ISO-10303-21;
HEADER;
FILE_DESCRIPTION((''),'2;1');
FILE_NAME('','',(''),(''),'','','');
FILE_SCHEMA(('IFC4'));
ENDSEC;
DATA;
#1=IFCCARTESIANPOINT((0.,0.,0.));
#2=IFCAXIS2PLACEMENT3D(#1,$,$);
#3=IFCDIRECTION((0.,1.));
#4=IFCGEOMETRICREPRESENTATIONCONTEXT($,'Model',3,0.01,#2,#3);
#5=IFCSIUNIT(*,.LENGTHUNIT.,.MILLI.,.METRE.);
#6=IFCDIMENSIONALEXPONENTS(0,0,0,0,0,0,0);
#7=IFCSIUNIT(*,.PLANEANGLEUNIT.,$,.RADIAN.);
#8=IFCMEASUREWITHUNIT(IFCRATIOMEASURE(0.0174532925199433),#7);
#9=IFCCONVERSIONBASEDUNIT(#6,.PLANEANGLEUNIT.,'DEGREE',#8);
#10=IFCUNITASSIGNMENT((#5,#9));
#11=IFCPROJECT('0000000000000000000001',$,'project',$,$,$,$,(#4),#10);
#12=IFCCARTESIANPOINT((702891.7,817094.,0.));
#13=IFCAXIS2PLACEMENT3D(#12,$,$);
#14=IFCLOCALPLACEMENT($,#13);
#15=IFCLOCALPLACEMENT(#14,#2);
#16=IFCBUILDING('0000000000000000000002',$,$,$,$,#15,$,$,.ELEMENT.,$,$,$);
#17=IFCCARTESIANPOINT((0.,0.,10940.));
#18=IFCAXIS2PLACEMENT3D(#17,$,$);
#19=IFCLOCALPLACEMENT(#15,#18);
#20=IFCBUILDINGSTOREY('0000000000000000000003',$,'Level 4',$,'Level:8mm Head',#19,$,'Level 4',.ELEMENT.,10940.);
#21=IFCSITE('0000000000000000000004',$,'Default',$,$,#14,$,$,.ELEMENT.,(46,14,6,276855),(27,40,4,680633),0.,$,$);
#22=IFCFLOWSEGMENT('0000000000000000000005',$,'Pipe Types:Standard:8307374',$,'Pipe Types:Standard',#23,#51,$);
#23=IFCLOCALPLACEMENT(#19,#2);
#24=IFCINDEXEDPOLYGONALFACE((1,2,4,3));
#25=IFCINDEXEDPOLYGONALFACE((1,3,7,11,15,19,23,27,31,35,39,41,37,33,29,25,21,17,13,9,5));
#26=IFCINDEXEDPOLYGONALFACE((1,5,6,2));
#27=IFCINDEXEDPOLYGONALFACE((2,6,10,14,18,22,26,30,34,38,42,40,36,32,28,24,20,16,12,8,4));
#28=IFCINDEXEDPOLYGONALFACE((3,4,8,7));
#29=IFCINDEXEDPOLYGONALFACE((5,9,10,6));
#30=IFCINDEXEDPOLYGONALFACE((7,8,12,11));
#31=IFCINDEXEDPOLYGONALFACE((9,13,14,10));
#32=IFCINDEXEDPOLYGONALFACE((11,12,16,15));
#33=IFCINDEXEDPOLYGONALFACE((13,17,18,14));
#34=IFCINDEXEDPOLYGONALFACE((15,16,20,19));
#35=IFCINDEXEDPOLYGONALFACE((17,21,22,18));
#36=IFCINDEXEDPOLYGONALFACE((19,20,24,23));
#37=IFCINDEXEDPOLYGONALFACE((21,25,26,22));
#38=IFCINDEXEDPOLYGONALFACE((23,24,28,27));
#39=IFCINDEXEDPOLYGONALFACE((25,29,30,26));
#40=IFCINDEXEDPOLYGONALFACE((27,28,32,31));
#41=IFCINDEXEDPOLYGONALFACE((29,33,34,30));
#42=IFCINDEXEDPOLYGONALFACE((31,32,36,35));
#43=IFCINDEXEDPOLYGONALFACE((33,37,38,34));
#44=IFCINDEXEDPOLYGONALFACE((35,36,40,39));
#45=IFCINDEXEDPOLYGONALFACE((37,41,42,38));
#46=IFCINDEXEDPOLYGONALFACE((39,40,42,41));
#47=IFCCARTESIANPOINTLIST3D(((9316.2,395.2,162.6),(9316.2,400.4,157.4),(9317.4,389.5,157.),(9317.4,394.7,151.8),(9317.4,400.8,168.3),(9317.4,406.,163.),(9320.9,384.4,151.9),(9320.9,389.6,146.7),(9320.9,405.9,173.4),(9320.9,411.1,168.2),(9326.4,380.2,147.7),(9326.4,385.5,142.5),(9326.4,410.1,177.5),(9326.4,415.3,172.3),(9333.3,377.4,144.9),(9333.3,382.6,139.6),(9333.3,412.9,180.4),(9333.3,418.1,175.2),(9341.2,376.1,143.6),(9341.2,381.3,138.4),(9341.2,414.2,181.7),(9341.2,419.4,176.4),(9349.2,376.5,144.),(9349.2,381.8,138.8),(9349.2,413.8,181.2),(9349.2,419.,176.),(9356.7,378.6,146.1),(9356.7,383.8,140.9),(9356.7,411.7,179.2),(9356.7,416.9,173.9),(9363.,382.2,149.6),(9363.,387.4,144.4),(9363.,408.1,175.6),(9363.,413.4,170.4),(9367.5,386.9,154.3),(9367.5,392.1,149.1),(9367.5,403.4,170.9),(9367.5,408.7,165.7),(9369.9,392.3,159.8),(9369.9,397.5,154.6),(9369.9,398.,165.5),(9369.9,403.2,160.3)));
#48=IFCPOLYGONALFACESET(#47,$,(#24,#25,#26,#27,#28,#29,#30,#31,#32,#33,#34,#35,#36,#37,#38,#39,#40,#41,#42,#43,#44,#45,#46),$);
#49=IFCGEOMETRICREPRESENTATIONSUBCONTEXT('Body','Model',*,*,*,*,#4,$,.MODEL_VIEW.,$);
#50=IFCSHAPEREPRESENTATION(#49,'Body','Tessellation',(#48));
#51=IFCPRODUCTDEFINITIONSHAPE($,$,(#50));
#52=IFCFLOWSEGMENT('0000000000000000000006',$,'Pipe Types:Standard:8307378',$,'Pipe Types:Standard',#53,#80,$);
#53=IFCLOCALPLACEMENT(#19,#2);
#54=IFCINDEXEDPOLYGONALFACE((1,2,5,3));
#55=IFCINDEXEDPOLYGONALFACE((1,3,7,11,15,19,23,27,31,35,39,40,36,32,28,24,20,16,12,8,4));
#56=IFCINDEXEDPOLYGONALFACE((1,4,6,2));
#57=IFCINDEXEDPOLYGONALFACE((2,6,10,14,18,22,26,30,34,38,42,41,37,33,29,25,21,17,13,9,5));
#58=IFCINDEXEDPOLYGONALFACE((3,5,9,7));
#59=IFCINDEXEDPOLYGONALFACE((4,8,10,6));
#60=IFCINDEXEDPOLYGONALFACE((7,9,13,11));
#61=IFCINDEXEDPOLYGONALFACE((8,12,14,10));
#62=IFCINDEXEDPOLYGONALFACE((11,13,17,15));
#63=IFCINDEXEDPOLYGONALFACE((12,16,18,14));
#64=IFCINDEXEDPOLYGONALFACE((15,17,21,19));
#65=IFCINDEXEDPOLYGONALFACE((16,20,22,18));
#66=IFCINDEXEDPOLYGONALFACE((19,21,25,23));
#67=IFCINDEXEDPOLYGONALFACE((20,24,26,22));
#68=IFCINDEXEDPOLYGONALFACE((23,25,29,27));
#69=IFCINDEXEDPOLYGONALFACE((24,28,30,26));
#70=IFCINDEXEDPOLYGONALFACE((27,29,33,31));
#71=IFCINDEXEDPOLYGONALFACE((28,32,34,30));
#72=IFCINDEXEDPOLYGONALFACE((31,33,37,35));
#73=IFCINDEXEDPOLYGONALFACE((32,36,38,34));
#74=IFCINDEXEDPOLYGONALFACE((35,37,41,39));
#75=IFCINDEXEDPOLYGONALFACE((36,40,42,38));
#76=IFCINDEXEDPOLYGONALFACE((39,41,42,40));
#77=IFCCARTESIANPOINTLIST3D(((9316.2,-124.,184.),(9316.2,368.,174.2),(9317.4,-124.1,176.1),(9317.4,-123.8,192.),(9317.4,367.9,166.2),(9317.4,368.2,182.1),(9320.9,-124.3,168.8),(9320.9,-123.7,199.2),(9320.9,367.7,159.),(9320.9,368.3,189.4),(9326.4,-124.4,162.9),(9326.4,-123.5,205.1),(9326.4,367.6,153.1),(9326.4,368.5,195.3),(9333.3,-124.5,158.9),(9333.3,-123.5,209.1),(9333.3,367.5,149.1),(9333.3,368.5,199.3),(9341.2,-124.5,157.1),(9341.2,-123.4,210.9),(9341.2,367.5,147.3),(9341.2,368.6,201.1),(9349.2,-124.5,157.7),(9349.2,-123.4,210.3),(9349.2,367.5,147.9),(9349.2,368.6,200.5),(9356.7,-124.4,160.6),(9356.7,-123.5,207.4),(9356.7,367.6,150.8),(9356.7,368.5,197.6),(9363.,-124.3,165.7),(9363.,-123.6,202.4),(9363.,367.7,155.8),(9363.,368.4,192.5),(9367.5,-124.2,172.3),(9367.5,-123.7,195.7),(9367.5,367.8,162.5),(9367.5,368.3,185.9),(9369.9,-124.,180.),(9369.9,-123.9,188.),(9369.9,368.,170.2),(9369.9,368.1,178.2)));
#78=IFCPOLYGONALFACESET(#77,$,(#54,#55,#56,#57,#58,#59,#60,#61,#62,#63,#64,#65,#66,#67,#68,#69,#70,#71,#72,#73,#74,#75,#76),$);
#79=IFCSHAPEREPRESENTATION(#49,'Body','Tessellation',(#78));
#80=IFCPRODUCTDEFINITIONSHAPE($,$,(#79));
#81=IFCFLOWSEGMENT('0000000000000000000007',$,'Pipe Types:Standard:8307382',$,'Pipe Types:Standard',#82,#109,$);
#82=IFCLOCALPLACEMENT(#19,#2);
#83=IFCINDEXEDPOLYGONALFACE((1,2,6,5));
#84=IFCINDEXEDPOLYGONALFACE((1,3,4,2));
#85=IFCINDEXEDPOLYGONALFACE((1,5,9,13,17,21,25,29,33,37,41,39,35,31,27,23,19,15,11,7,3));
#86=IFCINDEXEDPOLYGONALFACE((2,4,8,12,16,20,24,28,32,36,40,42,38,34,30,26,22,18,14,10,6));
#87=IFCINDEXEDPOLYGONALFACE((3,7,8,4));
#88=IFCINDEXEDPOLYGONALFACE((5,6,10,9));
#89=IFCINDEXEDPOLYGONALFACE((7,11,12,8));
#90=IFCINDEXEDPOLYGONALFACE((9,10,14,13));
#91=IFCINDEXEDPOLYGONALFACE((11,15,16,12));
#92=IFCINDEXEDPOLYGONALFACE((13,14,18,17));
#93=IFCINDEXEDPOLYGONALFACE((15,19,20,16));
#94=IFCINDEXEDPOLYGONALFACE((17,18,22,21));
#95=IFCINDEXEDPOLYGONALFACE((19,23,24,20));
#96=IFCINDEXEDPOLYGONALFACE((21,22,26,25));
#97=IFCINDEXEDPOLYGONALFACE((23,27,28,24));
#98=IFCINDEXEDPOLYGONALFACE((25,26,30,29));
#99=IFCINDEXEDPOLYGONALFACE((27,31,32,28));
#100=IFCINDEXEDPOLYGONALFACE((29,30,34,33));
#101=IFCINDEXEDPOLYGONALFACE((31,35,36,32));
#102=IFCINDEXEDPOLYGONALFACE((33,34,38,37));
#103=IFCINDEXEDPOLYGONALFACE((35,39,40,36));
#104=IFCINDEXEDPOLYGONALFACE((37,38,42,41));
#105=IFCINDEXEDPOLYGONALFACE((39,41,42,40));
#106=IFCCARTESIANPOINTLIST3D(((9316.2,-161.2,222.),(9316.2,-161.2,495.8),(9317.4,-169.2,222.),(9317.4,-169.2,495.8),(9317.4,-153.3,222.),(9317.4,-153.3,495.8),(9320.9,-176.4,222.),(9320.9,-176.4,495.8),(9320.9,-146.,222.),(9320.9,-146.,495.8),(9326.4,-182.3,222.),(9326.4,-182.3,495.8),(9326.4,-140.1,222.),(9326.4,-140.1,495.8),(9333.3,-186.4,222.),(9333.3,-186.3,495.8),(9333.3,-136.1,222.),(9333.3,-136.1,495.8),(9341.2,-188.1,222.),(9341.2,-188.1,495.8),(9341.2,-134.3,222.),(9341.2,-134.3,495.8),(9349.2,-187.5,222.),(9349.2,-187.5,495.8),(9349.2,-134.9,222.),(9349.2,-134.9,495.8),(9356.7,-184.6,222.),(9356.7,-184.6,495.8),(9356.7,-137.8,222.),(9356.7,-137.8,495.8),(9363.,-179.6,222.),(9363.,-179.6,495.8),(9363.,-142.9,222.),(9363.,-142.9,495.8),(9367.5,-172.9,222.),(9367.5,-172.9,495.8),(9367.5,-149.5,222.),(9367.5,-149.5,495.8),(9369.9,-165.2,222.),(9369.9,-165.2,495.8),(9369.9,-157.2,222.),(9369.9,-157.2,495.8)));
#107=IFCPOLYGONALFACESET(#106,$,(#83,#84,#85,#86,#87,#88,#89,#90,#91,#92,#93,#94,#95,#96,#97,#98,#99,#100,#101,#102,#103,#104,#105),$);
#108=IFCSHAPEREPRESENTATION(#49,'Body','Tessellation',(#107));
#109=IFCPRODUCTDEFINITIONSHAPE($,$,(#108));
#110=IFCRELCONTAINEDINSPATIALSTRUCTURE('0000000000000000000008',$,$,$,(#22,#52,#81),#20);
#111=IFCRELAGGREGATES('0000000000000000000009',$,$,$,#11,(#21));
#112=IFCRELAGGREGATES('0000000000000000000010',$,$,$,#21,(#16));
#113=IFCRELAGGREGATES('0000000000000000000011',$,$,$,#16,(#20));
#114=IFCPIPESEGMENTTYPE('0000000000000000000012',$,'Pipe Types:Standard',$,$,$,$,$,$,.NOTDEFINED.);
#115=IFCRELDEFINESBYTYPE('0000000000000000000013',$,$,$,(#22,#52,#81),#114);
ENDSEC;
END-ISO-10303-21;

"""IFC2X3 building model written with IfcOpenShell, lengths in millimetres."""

from ifc_helpers import new_model, entity, si_unit, converted_unit, direction, frame, frame_2d, origin, origin_2d_with_axis, place, context, subcontext, project, spatial, circle, extrude, type_object, element, save


model = new_model("IFC2X3")

# Units and contexts
model_context = context("Model", 3, precision=0.01, world=origin(), true_north=direction((0.0, 1.0)))
body_context = subcontext(model_context, "Body", "Model", "MODEL_VIEW")
ifc_project = project(units=[si_unit("LENGTHUNIT", "METRE", prefix="MILLI"), converted_unit("PLANEANGLEUNIT", "DEGREE", entity("IfcRatioMeasure", 0.0174532925199433), si_unit("PLANEANGLEUNIT", "RADIAN"), dimensions=[0, 0, 0, 0, 0, 0, 0])], contexts=[model_context])

# Site, building, storey
site_placement = place(None, frame((702891.7, 817094.0, 0.0)))
site = spatial("IfcSite", under=ifc_project, at=site_placement, Name="Default", CompositionType="ELEMENT", RefLatitude=(46, 14, 6, 276855), RefLongitude=(27, 40, 4, 680633), RefElevation=0.0)
building_placement = place(site_placement, origin())
building = spatial("IfcBuilding", under=site, at=building_placement, CompositionType="ELEMENT")
storey_placement = place(building_placement, frame((0.0, 0.0, 10940.0)))
storey = spatial("IfcBuildingStorey", under=building, at=storey_placement, Name="Level 4", ObjectType="Level:8mm Head", LongName="Level 4", CompositionType="ELEMENT", Elevation=10940.0)

# Flow segments
pipe_segment_type = type_object("IfcPipeSegmentType", Name="Pipe Types:Standard", PredefinedType="NOTDEFINED")
flow_segment_1_placement = place(storey_placement, origin())
element("IfcFlowSegment", 1, at=flow_segment_1_placement, inside=storey, type_object=pipe_segment_type, Name="Pipe Types:Standard:8307374", ObjectType="Pipe Types:Standard", context=body_context, shape_type="SweptSolid", body=[
    extrude(circle(Radius=27.0, at=origin_2d_with_axis()), frame((9343.2, 400.4, 157.4), z_axis=(0.0, -0.707107, 0.707107), x_axis=(-1.0, 0.0, 0.0)), (0.0, 0.0, 1.0), 7.4),
])
flow_segment_2_placement = place(storey_placement, origin())
element("IfcFlowSegment", 2, at=flow_segment_2_placement, inside=storey, type_object=pipe_segment_type, Name="Pipe Types:Standard:8307378", ObjectType="Pipe Types:Standard", context=body_context, shape_type="SweptSolid", body=[
    extrude(circle(Radius=27.0, at=origin_2d_with_axis()), frame((9343.2, 368.0, 174.2), z_axis=(0.0, -0.9998, 0.019996), x_axis=(-1.0, 0.0, 0.0)), (0.0, 0.0, 1.0), 492.1),
])
flow_segment_3_placement = place(storey_placement, origin())
element("IfcFlowSegment", 3, at=flow_segment_3_placement, inside=storey, type_object=pipe_segment_type, Name="Pipe Types:Standard:8307382", ObjectType="Pipe Types:Standard", context=body_context, shape_type="SweptSolid", body=[
    extrude(circle(Radius=27.0, at=frame_2d((0.0, 0.0), x_axis=(1.0, 0.0))), frame((9343.2, -161.2, 222.0), z_axis=(0.0, 0.000001, 1.0), x_axis=(-1.0, 0.0, 0.0)), (0.0, 0.0, 1.0), 273.7),
])

save(model, "model.ifc")
